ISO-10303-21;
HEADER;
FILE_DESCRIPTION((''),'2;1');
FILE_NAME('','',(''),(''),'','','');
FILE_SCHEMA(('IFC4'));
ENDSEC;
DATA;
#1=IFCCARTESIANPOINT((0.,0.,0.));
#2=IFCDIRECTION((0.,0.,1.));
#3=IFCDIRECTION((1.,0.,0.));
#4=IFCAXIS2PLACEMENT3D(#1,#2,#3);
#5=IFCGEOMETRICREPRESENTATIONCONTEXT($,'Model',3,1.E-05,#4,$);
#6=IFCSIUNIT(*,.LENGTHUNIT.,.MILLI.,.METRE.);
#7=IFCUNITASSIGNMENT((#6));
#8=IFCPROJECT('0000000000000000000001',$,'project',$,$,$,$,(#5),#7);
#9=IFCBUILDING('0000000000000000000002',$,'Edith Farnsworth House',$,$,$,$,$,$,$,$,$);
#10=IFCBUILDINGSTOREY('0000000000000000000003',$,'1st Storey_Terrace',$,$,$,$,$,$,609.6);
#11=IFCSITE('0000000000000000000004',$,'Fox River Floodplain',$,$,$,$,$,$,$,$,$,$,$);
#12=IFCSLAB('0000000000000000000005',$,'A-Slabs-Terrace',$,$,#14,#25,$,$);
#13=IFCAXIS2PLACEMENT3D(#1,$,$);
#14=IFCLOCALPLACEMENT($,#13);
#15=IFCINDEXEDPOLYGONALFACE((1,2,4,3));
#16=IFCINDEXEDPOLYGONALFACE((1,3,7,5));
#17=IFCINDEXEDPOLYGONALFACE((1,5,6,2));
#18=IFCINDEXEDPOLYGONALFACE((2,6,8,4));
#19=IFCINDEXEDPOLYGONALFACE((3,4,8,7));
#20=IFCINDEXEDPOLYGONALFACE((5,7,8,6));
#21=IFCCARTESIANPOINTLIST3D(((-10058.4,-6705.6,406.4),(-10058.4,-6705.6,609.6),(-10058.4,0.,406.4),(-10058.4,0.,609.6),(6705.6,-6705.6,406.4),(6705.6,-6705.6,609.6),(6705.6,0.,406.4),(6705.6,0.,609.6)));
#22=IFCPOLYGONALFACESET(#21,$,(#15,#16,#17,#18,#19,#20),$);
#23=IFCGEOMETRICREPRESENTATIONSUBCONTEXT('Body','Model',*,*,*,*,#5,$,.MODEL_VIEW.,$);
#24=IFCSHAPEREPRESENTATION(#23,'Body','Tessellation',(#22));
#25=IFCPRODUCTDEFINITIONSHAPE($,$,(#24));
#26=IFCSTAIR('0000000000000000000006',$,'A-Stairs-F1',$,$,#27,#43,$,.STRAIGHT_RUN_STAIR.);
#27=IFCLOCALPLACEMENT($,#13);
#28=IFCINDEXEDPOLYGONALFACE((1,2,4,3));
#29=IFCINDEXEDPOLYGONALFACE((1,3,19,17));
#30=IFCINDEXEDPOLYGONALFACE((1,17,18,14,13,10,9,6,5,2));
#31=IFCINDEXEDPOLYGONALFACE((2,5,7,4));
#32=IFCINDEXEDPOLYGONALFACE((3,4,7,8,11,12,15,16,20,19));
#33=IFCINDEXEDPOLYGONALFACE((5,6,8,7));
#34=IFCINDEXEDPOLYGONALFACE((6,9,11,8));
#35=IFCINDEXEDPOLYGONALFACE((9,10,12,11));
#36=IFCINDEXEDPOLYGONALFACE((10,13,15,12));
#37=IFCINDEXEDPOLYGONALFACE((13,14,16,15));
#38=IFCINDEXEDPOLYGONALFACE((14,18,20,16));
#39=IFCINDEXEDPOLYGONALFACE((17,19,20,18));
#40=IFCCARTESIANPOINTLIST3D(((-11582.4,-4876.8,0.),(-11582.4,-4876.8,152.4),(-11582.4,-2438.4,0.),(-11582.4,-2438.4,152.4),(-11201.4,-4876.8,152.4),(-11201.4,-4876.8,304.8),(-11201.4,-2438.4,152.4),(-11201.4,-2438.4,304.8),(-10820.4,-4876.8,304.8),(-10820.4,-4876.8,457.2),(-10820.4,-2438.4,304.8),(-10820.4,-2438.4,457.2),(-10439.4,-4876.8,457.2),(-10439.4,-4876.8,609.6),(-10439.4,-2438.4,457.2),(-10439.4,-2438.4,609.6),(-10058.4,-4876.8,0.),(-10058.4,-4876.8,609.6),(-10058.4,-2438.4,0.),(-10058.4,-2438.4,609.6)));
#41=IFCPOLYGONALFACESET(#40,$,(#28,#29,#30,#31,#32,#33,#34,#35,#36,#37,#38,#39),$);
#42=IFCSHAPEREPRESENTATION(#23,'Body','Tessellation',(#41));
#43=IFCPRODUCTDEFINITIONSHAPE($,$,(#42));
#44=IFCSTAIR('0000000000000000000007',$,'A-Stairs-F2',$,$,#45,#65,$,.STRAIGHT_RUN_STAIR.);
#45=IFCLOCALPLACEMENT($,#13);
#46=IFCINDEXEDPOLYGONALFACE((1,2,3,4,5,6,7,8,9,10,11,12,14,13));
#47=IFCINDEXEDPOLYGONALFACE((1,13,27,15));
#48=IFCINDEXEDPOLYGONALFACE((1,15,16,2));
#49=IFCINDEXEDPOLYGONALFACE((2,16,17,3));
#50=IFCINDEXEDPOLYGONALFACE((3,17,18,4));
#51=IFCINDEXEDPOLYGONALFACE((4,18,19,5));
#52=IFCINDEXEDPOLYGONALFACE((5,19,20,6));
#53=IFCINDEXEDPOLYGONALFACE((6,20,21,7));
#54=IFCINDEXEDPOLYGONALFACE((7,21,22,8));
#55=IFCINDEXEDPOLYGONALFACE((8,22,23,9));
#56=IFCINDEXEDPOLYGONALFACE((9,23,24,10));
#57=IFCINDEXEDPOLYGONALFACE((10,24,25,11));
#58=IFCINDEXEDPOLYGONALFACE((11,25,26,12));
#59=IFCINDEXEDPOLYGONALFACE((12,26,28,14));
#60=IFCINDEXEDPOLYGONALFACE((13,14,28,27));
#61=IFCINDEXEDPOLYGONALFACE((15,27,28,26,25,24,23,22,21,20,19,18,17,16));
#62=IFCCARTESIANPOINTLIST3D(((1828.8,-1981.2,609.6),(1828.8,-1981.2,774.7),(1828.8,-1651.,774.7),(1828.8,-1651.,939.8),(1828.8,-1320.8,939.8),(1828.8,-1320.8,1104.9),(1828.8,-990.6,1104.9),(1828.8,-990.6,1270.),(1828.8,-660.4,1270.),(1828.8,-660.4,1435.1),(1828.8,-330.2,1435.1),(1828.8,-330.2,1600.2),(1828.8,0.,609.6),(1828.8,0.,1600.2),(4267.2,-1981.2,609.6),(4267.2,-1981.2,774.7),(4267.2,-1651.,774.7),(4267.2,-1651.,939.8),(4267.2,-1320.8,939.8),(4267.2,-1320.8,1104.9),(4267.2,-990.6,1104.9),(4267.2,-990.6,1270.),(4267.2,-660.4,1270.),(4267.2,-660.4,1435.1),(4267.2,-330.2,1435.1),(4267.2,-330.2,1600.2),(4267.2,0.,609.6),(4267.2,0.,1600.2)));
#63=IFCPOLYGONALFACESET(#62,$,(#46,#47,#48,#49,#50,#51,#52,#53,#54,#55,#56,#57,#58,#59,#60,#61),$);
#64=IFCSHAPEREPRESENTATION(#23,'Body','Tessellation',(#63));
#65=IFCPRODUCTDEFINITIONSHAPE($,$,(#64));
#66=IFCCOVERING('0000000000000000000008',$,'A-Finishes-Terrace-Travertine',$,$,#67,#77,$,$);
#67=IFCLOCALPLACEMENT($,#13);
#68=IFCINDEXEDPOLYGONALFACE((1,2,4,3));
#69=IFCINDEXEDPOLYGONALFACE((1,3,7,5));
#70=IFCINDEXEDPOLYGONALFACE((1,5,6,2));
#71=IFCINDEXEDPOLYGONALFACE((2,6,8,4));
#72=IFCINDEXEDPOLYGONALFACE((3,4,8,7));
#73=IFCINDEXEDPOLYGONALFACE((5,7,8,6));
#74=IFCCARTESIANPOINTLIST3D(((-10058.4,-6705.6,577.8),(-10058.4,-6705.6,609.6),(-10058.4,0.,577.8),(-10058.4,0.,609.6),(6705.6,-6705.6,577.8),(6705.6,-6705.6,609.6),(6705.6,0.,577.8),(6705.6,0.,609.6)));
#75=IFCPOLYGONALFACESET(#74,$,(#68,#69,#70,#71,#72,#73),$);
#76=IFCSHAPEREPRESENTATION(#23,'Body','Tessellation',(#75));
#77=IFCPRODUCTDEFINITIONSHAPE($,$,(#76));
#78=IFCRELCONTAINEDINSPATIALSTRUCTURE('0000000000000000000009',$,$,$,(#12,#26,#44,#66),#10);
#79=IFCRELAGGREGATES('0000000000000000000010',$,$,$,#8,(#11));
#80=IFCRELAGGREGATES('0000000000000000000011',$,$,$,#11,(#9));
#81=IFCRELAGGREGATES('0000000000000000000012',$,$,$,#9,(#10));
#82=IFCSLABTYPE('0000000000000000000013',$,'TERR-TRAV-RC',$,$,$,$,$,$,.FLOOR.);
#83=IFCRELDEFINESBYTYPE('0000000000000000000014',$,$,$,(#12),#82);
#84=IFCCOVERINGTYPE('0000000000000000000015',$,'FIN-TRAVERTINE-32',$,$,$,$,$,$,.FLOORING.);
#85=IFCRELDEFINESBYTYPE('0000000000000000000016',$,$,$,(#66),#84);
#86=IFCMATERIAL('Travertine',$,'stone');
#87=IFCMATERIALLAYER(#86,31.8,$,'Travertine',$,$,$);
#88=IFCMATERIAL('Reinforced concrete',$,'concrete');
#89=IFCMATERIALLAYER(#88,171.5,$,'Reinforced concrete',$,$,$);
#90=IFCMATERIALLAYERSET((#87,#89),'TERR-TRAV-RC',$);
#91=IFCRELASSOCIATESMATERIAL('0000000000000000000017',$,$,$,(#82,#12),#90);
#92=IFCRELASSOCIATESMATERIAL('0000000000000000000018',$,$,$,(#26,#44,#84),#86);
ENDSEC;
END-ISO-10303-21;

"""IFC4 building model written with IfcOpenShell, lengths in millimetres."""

from ifc_helpers import new_model, si_unit, frame, origin, origin_with_axes, place, context, subcontext, project, spatial, polyline, indexed_curve, outline, extrude, material, layer, layer_set, layer_usage, type_object, element, save


model = new_model("IFC4")

# Units and contexts
model_context = context("Model", 3, precision=1e-05, world=origin_with_axes())
body_context = subcontext(model_context, "Body", "Model", "MODEL_VIEW")
ifc_project = project(units=[si_unit("LENGTHUNIT", "METRE", prefix="MILLI")], contexts=[model_context])

# Site, building, storey
site = spatial("IfcSite", under=ifc_project, Name="Fox River Floodplain")
building = spatial("IfcBuilding", under=site, Name="Edith Farnsworth House")
storey = spatial("IfcBuildingStorey", under=building, Name="1st Storey_Terrace", Elevation=609.6)

# Slab
ifc_material_1 = material(Name="Travertine", Category="stone")
ifc_layer_1 = layer(ifc_material_1, 31.8, Name="Travertine")
ifc_material_2 = material(Name="Reinforced concrete", Category="concrete")
ifc_layer_2 = layer(ifc_material_2, 171.5, Name="Reinforced concrete")
ifc_layer_set = layer_set([ifc_layer_1, ifc_layer_2], Name="TERR-TRAV-RC")
ifc_layer_usage = layer_usage(ifc_layer_set, "AXIS3", "POSITIVE", 0.0)
slab_type = type_object("IfcSlabType", Name="TERR-TRAV-RC", PredefinedType="FLOOR", material=ifc_layer_set)
slab_placement = place(None, frame((0.0, 0.0, 406.4), z_axis=(0.0, 0.0, 1.0), x_axis=(1.0, 0.0, 0.0)))
element("IfcSlab", 1, at=slab_placement, inside=storey, type_object=slab_type, material=ifc_layer_usage, Name="A-Slabs-Terrace", context=body_context, shape_type="SweptSolid", body=[
    extrude(outline(indexed_curve([(-10058.4, -6705.6), (6705.6, -6705.6), (6705.6, 0.0), (-10058.4, 0.0)])), None, (0.0, 0.0, 1.0), 203.2),
])

# Stairs
stair_1_placement = place(None, frame((-11582.4, -2438.4, 0.0), z_axis=(0.0, -1.0, 0.0), x_axis=(1.0, 0.0, 0.0)))
element("IfcStair", 2, at=stair_1_placement, inside=storey, material=ifc_material_1, Name="A-Stairs-F1", PredefinedType="STRAIGHT_RUN_STAIR", context=body_context, shape_type="SweptSolid", body=[
    extrude(outline(polyline([(0.0, 0.0), (0.0, 152.4), (381.0, 152.4), (381.0, 304.8), (762.0, 304.8), (762.0, 457.2), (1143.0, 457.2), (1143.0, 609.6), (1524.0, 609.6), (1524.0, 0.0), (0.0, 0.0)])), origin(), (0.0, 0.0, 1.0), 2438.4),
])
stair_2_placement = place(None, frame((1828.8, -1981.2, 609.6), z_axis=(1.0, 0.0, 0.0), x_axis=(0.0, 1.0, 0.0)))
element("IfcStair", 3, at=stair_2_placement, inside=storey, material=ifc_material_1, Name="A-Stairs-F2", PredefinedType="STRAIGHT_RUN_STAIR", context=body_context, shape_type="SweptSolid", body=[
    extrude(outline(polyline([(0.0, 0.0), (0.0, 165.1), (330.2, 165.1), (330.2, 330.2), (660.4, 330.2), (660.4, 495.3), (990.6, 495.3), (990.6, 660.4), (1320.8, 660.4), (1320.8, 825.5), (1651.0, 825.5), (1651.0, 990.6), (1981.2, 990.6), (1981.2, 0.0), (0.0, 0.0)])), origin(), (0.0, 0.0, 1.0), 2438.4),
])

# Covering
covering_type = type_object("IfcCoveringType", Name="FIN-TRAVERTINE-32", PredefinedType="FLOORING", material=ifc_material_1)
covering_placement = place(None, frame((0.0, 0.0, 577.8), z_axis=(0.0, 0.0, 1.0), x_axis=(1.0, 0.0, 0.0)))
element("IfcCovering", 4, at=covering_placement, inside=storey, type_object=covering_type, Name="A-Finishes-Terrace-Travertine", context=body_context, shape_type="SweptSolid", body=[
    extrude(outline(indexed_curve([(-10058.4, -6705.6), (6705.6, -6705.6), (6705.6, 0.0), (-10058.4, 0.0)])), None, (0.0, 0.0, 1.0), 31.8),
])

save(model, "model.ifc")
